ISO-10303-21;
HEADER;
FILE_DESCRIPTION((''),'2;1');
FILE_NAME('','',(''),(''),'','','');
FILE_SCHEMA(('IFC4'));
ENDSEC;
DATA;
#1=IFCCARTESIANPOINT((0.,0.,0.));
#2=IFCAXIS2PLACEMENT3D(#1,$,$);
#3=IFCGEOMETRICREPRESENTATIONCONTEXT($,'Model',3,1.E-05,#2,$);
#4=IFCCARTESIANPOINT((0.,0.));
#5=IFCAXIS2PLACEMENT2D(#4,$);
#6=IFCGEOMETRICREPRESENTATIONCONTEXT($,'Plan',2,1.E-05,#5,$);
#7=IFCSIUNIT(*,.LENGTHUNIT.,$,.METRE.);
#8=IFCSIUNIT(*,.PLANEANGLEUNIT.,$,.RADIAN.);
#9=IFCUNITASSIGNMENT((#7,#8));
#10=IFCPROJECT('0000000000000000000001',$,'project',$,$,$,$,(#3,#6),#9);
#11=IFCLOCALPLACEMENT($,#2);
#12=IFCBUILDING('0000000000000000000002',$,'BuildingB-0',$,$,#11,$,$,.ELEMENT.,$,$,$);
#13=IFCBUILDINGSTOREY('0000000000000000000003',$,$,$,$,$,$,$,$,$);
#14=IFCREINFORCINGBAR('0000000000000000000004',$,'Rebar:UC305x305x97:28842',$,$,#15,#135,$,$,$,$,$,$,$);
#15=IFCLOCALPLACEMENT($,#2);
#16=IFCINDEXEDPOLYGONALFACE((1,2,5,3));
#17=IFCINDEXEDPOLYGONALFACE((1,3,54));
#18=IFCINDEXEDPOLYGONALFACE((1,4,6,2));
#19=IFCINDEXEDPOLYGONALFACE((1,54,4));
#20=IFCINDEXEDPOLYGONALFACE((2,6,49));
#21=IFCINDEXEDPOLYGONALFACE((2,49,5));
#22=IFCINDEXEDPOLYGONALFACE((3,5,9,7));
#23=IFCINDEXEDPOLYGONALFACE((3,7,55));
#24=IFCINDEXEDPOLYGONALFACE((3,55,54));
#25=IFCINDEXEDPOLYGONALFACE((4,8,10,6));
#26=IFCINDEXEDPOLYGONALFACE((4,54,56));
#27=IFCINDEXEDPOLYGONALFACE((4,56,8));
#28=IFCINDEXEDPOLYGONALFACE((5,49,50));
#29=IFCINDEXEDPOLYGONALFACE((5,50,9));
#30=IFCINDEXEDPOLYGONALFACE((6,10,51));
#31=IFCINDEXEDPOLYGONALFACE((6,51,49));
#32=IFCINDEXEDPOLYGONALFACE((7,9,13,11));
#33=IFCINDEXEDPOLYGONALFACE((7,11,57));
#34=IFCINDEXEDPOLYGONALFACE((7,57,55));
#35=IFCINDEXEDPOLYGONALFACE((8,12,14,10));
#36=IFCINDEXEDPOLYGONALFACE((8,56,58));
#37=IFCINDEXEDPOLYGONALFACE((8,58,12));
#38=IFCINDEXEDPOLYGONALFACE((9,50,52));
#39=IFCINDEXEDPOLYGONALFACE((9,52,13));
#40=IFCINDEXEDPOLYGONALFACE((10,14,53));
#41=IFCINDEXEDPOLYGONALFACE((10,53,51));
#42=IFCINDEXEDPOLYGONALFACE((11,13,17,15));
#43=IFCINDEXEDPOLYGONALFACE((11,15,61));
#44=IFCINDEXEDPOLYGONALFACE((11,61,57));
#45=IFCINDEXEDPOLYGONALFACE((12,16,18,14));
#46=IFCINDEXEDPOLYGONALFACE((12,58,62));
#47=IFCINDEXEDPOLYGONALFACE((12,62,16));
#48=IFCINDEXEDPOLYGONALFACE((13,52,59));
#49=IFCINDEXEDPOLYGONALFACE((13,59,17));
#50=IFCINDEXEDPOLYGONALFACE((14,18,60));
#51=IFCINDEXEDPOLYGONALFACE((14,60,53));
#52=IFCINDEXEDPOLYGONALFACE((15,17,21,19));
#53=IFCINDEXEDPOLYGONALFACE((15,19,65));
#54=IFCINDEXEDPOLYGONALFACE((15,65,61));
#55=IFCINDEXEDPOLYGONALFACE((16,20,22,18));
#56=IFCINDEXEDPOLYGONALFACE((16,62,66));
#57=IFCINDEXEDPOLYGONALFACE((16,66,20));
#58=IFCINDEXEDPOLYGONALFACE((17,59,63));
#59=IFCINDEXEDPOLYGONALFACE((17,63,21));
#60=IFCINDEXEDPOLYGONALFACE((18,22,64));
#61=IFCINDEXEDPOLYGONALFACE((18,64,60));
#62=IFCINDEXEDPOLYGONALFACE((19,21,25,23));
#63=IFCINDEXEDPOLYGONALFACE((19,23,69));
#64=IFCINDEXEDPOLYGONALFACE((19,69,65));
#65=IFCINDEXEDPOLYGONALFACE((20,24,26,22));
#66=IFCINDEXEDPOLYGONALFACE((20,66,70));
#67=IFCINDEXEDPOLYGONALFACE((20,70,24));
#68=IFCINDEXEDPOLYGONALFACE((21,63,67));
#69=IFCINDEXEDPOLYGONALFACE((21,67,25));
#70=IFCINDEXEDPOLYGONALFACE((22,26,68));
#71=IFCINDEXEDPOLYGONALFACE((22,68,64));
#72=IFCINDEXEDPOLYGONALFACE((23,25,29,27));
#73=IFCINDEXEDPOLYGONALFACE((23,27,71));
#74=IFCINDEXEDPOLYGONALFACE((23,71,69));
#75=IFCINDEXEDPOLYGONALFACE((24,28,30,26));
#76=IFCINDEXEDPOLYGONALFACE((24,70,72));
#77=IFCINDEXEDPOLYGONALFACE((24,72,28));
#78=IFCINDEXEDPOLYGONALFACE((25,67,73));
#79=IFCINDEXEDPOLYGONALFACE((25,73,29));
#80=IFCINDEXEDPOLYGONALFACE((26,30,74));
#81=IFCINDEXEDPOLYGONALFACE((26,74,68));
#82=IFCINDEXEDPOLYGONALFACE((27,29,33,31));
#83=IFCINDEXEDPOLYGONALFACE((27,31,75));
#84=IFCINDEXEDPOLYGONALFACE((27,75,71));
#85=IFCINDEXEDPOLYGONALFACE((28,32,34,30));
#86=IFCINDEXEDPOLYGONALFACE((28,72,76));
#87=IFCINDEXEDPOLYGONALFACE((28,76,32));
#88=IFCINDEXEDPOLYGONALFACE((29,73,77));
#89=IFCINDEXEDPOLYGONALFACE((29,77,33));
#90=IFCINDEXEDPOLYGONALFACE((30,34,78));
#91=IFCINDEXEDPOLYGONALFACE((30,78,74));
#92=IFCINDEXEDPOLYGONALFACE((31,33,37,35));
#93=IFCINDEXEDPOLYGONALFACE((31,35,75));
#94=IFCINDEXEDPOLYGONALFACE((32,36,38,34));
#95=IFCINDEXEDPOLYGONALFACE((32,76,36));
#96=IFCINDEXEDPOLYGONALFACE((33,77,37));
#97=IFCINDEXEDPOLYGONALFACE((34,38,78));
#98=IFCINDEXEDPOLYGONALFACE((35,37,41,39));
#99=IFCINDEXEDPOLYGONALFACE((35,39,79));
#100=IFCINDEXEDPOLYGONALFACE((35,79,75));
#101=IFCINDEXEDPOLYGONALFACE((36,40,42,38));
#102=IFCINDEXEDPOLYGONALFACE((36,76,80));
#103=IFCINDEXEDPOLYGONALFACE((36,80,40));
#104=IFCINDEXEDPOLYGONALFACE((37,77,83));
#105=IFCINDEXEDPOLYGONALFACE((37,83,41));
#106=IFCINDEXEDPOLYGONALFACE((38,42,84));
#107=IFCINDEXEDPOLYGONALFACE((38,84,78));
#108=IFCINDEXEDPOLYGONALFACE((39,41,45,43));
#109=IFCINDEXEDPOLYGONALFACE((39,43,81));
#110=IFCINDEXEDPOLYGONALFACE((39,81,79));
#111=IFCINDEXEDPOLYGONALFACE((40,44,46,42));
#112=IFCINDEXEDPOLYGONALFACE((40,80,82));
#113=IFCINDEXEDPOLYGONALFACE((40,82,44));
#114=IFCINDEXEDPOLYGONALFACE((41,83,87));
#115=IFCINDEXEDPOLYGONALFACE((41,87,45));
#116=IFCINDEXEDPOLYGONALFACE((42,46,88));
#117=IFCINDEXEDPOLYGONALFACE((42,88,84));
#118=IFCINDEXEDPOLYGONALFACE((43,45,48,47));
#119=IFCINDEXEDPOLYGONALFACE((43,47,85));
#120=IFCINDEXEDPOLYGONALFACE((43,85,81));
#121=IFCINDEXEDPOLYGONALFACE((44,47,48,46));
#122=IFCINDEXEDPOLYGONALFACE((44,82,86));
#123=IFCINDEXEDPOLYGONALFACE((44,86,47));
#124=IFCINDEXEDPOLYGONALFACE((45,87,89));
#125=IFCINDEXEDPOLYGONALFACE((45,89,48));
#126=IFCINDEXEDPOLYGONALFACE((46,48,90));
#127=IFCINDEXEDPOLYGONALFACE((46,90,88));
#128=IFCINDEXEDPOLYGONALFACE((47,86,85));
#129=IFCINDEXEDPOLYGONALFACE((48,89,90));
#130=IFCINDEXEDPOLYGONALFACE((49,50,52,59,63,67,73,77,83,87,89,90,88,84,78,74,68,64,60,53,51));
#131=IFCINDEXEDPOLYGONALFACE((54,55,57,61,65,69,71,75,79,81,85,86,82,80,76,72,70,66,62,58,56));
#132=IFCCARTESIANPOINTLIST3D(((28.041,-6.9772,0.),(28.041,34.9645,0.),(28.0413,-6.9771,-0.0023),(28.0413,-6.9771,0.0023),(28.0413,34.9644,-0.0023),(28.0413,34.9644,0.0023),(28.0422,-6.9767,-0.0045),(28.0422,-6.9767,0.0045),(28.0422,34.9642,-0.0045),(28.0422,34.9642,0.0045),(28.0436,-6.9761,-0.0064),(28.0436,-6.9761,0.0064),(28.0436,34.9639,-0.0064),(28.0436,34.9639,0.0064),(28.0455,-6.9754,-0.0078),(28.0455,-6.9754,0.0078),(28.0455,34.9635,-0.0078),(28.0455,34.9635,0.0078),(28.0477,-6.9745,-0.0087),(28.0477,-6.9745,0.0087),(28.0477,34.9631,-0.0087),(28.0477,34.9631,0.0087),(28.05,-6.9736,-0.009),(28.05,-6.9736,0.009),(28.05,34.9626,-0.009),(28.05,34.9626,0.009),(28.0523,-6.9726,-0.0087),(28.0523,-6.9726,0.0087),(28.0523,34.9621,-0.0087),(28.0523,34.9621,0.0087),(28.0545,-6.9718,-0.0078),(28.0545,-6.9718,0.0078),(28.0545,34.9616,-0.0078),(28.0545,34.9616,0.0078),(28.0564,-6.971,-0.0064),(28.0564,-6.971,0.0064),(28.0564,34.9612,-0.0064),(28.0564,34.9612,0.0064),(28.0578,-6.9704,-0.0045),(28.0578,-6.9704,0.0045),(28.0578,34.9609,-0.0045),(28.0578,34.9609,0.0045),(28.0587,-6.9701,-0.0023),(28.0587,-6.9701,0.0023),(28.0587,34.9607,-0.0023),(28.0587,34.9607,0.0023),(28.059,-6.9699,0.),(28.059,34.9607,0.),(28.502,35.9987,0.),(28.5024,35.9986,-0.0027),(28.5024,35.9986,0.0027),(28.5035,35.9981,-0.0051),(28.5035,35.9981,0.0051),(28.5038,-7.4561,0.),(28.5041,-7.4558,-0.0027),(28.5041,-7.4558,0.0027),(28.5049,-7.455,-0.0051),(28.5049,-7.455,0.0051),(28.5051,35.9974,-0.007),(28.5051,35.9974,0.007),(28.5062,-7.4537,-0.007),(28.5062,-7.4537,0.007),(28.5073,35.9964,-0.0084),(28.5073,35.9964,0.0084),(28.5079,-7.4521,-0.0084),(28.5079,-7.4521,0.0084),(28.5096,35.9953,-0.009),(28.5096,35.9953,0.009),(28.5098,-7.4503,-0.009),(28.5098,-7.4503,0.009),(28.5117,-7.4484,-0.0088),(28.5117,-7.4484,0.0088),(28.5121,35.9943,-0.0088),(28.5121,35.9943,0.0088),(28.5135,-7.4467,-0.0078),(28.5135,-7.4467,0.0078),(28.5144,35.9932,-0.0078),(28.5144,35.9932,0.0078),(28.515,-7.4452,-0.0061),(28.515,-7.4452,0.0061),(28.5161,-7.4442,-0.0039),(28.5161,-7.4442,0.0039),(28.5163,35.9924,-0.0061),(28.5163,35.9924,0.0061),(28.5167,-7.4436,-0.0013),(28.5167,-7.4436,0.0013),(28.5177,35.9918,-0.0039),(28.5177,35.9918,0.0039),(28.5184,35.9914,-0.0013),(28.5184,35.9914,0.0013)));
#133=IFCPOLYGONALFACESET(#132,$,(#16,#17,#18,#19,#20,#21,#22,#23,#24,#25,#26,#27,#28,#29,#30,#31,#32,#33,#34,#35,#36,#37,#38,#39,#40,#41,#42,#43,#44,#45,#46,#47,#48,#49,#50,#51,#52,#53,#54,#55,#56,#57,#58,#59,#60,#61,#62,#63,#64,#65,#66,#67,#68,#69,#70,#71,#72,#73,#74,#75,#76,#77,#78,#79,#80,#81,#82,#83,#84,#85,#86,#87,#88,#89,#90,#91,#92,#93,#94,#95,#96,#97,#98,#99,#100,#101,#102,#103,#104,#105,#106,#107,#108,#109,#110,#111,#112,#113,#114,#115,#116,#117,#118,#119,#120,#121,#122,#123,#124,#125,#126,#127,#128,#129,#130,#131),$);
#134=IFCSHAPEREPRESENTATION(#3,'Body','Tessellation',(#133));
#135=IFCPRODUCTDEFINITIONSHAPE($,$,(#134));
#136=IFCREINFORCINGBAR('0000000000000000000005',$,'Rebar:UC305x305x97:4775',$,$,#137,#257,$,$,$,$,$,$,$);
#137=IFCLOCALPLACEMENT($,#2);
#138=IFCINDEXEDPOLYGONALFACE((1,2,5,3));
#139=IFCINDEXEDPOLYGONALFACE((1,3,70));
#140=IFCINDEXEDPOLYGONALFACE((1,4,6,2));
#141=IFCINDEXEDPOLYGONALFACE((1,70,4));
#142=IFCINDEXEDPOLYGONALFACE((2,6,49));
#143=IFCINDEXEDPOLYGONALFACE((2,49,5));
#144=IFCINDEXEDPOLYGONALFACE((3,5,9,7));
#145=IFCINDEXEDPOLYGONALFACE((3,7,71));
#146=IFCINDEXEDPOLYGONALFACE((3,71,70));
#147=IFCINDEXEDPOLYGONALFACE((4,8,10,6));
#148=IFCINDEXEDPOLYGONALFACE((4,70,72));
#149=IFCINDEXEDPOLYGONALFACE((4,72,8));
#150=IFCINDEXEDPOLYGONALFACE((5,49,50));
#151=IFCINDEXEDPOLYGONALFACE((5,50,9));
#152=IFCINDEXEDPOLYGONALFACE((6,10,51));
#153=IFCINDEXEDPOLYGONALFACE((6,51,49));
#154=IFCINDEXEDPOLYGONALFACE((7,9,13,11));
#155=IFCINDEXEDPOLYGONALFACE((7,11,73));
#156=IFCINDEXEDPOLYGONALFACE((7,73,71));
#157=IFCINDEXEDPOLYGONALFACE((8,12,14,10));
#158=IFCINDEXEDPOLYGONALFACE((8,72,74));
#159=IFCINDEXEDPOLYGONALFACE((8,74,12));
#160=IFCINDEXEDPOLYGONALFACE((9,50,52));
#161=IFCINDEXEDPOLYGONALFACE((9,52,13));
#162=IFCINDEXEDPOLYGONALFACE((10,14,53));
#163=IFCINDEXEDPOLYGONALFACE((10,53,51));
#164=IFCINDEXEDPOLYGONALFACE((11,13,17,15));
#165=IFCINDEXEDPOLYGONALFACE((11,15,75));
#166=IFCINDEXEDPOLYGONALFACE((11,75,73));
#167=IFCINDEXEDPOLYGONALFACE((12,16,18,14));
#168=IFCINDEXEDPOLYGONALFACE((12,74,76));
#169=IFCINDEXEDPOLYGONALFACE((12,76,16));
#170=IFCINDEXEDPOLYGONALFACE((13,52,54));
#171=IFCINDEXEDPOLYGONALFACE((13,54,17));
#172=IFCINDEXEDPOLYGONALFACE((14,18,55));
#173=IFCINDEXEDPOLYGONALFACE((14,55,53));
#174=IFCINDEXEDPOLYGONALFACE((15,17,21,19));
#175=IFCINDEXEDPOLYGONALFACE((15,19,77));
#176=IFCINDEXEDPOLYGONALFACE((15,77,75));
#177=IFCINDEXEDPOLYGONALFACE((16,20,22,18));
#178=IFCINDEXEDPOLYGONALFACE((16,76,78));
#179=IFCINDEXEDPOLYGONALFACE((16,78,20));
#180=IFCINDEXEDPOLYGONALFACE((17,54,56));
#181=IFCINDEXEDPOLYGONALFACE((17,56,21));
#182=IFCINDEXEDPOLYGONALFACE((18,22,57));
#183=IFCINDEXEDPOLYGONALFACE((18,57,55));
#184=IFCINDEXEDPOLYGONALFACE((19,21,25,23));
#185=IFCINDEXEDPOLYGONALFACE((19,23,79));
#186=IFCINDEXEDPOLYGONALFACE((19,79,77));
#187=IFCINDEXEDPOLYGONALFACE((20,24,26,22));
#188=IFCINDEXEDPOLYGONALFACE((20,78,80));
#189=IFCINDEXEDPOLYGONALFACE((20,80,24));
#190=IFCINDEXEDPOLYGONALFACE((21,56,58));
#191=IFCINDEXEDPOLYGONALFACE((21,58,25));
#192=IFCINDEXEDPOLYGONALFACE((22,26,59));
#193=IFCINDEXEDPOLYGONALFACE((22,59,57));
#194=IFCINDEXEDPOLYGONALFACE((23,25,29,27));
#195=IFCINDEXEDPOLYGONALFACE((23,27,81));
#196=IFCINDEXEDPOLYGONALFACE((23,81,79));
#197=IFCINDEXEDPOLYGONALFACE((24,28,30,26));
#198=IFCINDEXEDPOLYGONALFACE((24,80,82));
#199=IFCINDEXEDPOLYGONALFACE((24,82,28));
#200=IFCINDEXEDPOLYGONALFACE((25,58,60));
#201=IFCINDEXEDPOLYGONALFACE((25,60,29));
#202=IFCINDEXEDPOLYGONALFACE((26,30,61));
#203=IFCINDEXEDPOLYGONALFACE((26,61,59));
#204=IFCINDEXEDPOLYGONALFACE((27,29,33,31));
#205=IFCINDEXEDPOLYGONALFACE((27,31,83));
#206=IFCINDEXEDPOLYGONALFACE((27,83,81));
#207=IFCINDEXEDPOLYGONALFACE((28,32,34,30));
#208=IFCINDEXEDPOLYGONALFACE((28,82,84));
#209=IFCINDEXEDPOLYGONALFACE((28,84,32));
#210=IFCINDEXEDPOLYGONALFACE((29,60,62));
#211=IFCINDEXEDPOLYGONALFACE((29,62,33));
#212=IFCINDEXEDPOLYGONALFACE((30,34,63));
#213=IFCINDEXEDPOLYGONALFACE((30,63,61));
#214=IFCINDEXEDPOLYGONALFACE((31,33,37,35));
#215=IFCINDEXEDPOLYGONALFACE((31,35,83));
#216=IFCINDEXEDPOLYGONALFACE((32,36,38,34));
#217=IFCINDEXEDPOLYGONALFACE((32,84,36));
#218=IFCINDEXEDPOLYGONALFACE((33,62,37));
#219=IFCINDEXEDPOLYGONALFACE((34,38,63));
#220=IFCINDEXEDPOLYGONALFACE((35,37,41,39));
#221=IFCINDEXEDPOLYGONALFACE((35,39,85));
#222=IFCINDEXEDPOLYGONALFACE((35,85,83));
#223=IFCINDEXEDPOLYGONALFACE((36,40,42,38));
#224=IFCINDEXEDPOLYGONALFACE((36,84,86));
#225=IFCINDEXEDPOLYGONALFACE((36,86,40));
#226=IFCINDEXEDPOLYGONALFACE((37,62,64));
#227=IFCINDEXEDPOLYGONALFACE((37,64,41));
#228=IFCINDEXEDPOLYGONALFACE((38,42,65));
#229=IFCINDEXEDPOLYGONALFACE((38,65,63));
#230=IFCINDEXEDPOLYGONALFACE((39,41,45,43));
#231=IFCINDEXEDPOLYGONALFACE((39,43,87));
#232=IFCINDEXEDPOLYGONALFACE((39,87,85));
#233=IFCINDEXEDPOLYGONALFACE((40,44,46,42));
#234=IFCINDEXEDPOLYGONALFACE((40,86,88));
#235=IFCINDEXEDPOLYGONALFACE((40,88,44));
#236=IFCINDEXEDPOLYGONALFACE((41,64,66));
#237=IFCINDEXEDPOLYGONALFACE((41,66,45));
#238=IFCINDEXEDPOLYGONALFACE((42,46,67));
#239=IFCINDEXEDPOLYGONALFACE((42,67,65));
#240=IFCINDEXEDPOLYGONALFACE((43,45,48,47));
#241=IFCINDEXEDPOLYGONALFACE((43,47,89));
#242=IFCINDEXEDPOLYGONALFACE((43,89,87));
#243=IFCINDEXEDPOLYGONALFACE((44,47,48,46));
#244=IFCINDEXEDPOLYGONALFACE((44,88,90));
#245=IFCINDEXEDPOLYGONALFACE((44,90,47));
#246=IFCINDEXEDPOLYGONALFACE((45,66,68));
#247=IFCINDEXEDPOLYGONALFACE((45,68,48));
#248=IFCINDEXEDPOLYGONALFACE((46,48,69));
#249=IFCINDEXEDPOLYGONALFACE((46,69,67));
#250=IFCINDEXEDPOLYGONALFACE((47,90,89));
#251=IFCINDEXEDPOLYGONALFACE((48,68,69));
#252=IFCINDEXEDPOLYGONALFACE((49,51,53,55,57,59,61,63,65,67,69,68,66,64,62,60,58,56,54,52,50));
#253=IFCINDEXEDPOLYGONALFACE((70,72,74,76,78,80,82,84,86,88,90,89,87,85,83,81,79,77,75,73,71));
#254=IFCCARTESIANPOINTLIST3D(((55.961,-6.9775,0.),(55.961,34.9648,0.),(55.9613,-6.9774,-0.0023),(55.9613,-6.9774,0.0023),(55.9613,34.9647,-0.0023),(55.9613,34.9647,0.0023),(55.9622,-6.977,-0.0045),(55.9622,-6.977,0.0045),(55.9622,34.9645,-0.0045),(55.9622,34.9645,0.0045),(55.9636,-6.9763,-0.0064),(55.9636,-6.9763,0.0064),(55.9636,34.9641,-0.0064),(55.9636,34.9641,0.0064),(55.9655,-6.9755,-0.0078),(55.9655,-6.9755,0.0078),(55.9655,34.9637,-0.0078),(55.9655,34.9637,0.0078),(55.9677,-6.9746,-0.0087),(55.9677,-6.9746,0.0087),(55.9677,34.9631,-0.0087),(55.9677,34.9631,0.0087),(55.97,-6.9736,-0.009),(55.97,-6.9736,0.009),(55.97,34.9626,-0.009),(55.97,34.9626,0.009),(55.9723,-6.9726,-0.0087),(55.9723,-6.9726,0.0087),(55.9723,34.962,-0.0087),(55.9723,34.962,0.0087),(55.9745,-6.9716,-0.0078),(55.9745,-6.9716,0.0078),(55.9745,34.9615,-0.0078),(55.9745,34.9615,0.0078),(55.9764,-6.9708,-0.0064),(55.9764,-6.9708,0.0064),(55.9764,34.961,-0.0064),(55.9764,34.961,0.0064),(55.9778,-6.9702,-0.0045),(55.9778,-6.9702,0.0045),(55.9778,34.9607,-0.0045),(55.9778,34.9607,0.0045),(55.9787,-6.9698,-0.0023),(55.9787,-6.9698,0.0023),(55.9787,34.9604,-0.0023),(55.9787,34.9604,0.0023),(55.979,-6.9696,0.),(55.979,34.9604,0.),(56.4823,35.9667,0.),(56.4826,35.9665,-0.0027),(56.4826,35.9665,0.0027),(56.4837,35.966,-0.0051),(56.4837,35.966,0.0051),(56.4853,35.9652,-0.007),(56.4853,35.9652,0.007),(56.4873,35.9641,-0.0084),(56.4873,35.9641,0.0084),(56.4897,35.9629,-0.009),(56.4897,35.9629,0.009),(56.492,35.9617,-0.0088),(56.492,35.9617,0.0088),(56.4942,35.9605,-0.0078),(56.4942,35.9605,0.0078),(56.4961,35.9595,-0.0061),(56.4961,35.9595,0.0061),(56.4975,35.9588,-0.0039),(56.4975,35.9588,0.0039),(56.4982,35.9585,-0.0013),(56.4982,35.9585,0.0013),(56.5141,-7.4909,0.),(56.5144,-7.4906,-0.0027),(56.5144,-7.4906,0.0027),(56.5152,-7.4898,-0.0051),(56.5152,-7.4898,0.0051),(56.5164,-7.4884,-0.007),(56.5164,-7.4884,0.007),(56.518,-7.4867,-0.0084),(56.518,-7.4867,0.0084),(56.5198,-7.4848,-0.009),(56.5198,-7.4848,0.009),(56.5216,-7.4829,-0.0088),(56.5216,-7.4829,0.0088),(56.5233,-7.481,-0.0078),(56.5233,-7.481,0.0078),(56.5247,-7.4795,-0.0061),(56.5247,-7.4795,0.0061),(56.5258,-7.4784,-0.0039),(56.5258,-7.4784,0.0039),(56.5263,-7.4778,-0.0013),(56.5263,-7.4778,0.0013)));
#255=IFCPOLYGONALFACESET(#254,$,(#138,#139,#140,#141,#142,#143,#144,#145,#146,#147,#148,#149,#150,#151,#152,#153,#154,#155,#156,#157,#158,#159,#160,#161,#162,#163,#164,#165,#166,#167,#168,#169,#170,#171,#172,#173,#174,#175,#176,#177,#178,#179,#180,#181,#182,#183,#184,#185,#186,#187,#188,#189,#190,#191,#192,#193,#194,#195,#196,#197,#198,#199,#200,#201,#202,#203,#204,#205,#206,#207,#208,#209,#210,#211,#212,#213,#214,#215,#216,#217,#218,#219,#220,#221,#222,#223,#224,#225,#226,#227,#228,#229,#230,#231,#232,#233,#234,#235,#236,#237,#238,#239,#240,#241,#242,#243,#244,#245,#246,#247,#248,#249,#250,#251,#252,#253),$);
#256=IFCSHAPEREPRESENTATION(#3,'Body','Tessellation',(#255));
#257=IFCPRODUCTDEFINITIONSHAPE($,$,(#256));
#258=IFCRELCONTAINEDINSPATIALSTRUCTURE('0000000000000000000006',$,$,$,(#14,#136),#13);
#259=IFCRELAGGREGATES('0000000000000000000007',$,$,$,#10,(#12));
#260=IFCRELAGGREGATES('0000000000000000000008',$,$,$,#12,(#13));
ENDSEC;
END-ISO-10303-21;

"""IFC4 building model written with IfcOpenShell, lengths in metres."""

from ifc_helpers import new_model, entity, si_unit, origin, origin_2d, place, context, project, spatial, element, save


model = new_model("IFC4")

# Units and contexts
model_context = context("Model", 3, precision=1e-05, world=origin())
plan_context = context("Plan", 2, precision=1e-05, world=origin_2d())
ifc_project = project(units=[si_unit("LENGTHUNIT", "METRE"), si_unit("PLANEANGLEUNIT", "RADIAN")], contexts=[model_context, plan_context])

# Building, storey
building_placement = place(None, origin())
building = spatial("IfcBuilding", under=ifc_project, at=building_placement, Name="BuildingB-0", CompositionType="ELEMENT")
storey = spatial("IfcBuildingStorey", under=building)

# Reinforcing bars
element("IfcReinforcingBar", 1, inside=storey, Name="Rebar:UC305x305x97:28842", context=model_context, shape_type="SweptSolid", body=[
    entity("IfcSurfaceCurveSweptAreaSolid", entity("IfcCircleProfileDef", "AREA", None, None, 0.009), None, entity("IfcPolyline", [entity("IfcCartesianPoint", [28.5103, 35.9951, 0.0]), entity("IfcCartesianPoint", [28.05, 34.9626, 0.0]), entity("IfcCartesianPoint", [28.05, -6.9736, 0.0]), entity("IfcCartesianPoint", [28.5103, -7.4498, 0.0])]), None, None, entity("IfcPlane", entity("IfcAxis2Placement3D", entity("IfcCartesianPoint", [28.5103, 35.9951, 0.0]), entity("IfcDirection", [1.0, -0.000167, 0.0]), entity("IfcDirection", [0.0, -1.0, 0.0])))),
])
element("IfcReinforcingBar", 2, inside=storey, Name="Rebar:UC305x305x97:4775", context=model_context, shape_type="SweptSolid", body=[
    entity("IfcSurfaceCurveSweptAreaSolid", entity("IfcCircleProfileDef", "AREA", None, None, 0.009), None, entity("IfcPolyline", [entity("IfcCartesianPoint", [56.5203, -7.4843, 0.0]), entity("IfcCartesianPoint", [55.97, -6.9736, 0.0]), entity("IfcCartesianPoint", [55.97, 34.9626, 0.0]), entity("IfcCartesianPoint", [56.4903, 35.9626, 0.0])]), None, None, entity("IfcPlane", entity("IfcAxis2Placement3D", entity("IfcCartesianPoint", [56.5203, -7.4843, 0.0]), entity("IfcDirection", [1.0, -0.000167, 0.0]), entity("IfcDirection", [0.0, 1.0, 0.0])))),
])

save(model, "model.ifc")
